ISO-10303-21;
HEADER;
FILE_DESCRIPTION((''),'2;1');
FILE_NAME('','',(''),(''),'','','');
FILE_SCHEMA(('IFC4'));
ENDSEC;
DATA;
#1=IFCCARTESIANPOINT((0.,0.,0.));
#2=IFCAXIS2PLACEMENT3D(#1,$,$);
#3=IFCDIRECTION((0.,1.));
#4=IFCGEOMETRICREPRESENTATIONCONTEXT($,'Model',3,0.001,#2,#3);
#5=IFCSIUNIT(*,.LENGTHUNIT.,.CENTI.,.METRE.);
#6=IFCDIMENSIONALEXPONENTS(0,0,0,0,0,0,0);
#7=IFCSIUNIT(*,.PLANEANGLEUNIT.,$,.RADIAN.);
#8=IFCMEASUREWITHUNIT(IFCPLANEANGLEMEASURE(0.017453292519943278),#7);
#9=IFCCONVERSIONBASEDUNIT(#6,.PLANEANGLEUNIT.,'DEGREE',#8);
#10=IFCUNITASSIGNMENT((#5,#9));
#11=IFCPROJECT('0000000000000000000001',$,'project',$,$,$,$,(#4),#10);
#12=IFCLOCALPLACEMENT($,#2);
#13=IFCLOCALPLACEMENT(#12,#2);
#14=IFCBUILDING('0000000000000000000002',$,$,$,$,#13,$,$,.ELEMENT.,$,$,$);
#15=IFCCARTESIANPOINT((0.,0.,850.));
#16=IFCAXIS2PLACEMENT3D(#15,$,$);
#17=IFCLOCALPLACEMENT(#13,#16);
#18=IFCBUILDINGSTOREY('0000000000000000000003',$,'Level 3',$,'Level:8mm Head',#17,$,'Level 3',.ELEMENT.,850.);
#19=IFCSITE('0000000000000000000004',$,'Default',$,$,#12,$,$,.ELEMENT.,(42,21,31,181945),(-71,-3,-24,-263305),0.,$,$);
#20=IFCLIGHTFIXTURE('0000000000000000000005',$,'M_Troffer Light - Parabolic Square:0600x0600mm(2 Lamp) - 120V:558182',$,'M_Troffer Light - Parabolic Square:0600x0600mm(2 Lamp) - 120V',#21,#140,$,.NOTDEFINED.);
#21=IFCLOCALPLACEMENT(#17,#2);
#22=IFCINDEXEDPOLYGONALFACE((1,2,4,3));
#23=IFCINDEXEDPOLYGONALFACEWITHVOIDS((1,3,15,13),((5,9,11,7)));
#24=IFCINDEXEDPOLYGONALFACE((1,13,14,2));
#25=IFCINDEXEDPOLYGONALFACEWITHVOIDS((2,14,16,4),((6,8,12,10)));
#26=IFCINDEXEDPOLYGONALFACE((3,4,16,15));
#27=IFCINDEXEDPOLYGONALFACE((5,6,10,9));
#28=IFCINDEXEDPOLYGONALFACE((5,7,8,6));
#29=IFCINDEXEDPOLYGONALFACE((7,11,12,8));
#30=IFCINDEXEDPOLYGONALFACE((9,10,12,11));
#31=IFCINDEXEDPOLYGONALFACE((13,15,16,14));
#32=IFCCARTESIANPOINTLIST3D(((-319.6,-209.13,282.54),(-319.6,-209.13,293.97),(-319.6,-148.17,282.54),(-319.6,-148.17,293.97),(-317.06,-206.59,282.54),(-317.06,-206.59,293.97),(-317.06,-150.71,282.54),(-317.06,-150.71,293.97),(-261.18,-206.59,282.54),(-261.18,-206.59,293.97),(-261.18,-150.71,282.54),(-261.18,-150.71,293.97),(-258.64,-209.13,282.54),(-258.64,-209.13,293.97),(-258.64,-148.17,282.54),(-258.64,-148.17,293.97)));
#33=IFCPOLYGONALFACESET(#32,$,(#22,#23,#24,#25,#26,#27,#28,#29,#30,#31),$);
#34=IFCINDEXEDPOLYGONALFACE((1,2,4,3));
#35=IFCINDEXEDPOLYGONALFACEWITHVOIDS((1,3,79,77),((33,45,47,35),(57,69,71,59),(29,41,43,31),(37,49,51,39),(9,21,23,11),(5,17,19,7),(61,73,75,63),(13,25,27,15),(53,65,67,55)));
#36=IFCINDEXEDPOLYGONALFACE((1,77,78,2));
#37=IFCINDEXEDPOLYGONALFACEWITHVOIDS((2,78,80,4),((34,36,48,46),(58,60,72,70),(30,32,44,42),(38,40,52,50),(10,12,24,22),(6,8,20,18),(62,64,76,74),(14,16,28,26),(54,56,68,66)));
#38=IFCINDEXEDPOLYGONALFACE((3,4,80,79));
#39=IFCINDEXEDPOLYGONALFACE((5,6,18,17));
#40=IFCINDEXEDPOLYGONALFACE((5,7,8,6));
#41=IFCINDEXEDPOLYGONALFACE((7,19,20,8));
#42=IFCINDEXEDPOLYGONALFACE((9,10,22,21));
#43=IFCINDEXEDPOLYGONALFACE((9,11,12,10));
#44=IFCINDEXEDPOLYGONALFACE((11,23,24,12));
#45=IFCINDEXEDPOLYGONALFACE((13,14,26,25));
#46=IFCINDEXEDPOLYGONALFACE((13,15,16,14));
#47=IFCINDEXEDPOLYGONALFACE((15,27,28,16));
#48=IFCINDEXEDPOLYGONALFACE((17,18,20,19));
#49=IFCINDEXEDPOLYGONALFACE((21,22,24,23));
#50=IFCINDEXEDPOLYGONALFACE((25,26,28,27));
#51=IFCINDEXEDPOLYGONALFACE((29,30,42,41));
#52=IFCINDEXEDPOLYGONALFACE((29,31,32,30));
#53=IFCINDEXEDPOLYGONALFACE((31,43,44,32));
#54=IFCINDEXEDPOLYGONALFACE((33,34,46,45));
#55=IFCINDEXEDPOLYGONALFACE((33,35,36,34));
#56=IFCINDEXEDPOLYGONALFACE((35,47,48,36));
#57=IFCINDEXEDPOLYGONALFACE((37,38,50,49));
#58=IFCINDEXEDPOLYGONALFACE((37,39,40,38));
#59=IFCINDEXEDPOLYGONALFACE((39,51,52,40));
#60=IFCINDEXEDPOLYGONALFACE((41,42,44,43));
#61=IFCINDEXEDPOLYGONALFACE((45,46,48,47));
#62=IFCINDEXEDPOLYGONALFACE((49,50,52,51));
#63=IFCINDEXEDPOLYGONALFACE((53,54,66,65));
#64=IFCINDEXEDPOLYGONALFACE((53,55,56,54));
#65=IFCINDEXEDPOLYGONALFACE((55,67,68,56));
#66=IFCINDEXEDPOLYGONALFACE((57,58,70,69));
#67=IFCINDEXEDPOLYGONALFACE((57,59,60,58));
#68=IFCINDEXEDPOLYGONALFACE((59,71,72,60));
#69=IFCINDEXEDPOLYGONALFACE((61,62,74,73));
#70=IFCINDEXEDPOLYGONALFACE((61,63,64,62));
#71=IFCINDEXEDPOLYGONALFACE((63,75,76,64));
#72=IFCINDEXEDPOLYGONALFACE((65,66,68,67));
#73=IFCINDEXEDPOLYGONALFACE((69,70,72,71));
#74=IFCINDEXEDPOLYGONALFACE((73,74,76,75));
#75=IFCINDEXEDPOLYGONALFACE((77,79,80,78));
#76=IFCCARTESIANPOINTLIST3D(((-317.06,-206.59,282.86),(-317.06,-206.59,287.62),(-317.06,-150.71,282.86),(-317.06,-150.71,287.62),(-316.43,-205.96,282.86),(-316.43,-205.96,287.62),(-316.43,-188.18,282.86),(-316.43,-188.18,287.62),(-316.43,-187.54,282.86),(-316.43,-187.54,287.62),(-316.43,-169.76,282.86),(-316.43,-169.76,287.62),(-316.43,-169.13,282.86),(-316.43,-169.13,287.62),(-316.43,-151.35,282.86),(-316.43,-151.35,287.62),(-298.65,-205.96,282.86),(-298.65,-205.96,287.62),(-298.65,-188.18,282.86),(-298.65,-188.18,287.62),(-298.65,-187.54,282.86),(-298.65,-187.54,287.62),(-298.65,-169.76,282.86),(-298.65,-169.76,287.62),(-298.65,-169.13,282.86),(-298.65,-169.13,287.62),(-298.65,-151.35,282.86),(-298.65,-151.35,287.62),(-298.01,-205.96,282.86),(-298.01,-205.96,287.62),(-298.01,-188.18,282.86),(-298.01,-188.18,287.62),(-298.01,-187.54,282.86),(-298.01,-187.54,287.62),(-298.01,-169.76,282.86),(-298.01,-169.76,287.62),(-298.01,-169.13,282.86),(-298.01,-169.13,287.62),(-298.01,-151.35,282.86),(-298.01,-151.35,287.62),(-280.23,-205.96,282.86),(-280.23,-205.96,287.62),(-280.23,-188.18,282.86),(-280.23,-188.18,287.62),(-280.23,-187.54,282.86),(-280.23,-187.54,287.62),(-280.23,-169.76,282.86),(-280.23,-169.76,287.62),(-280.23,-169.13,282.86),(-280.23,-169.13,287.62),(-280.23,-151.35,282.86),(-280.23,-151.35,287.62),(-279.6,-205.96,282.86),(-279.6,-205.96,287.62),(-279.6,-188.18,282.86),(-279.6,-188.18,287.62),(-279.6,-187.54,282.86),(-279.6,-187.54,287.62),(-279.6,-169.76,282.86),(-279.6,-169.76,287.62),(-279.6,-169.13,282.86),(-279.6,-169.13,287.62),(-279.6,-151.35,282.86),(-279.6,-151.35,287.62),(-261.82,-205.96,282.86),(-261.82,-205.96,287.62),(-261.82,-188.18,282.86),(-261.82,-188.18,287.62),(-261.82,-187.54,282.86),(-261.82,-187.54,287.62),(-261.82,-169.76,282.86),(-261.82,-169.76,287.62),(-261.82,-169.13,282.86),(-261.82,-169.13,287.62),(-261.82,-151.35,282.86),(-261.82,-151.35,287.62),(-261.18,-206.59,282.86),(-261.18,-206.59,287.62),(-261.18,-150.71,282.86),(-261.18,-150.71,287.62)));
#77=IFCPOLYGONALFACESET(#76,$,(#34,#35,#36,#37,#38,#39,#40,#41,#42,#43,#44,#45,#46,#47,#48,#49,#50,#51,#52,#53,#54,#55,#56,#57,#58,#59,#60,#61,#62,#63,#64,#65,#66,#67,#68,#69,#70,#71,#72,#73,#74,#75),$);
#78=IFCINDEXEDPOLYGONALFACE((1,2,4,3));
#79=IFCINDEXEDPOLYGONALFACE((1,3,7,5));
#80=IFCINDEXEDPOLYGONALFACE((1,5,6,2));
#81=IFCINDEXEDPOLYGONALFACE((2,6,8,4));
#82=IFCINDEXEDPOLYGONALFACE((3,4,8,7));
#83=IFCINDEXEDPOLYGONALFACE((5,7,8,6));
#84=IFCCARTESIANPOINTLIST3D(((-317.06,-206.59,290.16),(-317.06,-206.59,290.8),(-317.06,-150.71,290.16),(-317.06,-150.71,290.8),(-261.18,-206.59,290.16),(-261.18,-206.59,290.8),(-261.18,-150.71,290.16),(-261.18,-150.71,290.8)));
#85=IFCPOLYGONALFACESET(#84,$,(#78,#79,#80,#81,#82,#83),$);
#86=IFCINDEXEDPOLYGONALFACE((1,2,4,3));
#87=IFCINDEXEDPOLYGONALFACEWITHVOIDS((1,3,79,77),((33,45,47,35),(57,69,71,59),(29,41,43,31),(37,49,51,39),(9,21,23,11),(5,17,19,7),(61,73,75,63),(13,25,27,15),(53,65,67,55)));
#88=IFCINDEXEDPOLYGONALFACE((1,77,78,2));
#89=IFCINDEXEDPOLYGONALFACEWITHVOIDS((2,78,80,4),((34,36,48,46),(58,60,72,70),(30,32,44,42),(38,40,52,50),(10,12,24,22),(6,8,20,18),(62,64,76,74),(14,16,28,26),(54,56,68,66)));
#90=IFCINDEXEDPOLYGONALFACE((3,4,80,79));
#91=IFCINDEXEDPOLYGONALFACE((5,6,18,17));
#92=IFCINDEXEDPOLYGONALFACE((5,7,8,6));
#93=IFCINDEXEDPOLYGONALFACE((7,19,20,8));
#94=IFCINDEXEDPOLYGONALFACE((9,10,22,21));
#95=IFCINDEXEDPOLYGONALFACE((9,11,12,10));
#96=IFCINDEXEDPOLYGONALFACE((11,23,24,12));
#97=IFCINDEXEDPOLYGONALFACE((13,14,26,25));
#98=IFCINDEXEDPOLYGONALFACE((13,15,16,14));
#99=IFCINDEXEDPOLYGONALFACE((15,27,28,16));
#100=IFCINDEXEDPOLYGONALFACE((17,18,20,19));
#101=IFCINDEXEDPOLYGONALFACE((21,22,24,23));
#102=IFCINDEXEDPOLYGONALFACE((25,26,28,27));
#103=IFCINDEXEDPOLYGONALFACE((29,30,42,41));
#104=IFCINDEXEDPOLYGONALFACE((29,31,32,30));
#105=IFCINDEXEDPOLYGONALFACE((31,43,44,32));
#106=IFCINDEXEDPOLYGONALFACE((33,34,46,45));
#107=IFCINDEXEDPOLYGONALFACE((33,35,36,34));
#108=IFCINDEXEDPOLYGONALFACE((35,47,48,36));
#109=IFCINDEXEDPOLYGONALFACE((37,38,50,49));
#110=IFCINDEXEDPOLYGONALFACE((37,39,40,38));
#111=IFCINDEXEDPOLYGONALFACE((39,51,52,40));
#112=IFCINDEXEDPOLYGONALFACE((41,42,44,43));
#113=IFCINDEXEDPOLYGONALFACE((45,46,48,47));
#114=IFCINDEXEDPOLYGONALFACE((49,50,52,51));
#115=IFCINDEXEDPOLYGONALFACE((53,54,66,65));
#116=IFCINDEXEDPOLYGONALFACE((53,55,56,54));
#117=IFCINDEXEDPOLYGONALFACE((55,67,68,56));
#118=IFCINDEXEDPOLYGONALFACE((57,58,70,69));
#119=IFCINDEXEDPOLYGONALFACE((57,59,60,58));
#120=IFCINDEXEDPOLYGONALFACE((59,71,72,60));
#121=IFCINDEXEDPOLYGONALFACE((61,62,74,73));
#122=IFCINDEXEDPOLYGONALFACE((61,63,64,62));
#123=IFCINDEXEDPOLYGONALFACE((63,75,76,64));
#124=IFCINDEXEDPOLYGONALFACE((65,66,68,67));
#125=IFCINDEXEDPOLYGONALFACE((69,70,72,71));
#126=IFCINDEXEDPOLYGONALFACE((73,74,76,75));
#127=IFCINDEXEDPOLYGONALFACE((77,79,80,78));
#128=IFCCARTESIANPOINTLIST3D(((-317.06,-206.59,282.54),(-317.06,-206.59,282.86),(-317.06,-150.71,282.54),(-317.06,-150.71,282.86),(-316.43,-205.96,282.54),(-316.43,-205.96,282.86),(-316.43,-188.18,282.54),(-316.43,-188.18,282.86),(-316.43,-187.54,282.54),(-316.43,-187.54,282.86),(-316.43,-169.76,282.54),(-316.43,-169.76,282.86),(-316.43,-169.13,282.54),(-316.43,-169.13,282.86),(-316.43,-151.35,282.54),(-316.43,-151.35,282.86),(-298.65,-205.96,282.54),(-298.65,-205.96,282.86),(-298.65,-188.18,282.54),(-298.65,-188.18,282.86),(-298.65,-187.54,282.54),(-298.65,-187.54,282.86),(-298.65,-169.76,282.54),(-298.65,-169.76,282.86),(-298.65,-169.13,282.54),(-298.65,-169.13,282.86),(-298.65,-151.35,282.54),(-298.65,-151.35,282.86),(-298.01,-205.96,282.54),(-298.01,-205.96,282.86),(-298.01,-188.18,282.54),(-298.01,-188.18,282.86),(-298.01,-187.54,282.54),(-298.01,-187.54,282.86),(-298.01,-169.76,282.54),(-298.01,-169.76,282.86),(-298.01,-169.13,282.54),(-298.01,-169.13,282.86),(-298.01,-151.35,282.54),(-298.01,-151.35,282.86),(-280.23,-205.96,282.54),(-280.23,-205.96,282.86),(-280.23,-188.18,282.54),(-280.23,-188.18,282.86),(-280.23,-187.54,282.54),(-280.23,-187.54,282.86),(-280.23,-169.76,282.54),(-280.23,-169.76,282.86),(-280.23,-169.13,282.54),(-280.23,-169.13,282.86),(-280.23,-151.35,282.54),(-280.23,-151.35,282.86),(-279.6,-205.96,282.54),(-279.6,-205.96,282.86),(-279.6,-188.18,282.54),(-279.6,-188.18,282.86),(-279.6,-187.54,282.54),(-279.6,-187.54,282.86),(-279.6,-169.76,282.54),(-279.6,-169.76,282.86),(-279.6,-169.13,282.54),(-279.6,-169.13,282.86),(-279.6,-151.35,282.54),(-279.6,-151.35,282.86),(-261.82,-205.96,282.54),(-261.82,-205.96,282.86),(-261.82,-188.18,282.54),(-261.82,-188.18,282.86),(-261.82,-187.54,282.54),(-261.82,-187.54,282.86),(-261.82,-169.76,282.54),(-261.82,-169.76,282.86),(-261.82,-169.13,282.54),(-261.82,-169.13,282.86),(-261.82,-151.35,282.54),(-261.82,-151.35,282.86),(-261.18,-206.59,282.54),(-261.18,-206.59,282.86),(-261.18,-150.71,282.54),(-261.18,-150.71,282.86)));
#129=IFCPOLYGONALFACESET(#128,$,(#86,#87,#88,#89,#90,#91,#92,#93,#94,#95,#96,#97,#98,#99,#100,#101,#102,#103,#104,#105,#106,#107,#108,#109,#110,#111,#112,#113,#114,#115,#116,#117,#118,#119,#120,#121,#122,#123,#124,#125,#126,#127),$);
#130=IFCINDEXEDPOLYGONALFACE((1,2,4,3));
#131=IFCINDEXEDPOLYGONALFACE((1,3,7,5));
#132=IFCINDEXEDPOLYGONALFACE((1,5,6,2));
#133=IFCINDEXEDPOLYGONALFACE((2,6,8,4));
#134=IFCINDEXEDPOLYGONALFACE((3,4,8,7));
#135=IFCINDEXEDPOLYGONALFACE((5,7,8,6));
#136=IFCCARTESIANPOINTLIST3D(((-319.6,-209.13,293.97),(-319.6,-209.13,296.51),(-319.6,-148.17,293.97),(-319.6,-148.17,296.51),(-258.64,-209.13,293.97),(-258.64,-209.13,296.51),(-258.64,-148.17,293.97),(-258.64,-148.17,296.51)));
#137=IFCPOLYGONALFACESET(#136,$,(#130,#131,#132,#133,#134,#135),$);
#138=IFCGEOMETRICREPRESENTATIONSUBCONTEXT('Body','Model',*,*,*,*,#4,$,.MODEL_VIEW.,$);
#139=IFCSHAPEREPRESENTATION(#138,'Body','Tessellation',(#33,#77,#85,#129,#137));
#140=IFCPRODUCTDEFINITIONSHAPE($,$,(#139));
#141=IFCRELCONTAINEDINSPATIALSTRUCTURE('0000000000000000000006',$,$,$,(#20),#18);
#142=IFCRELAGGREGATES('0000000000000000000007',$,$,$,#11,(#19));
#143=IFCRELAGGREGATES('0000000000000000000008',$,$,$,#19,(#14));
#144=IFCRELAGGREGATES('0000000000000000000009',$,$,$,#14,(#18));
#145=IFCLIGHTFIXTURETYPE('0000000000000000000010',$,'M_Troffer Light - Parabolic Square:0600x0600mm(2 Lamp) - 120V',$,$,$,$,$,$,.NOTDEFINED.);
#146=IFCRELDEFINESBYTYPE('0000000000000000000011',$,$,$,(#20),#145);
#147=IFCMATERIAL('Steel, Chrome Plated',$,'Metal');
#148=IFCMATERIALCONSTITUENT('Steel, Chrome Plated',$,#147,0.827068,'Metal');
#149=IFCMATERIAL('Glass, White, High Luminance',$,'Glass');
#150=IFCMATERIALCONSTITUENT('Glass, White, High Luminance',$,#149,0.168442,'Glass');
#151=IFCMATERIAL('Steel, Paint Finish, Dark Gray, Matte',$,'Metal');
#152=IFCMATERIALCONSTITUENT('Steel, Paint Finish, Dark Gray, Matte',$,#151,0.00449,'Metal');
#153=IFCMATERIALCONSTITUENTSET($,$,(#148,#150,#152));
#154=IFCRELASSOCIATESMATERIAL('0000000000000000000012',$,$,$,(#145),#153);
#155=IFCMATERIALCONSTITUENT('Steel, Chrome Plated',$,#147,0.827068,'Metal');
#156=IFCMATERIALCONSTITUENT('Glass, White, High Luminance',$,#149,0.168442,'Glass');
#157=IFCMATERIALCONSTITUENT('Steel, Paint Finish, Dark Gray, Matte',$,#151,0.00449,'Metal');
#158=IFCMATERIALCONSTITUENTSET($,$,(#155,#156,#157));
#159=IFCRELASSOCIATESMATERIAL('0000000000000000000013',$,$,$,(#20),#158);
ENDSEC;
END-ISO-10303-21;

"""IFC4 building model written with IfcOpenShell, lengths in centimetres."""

from ifc_helpers import new_model, entity, si_unit, converted_unit, direction, frame, origin, place, context, subcontext, project, spatial, indexed_curve, outline, extrude, source, transform, mapped, material, constituent, constituent_set, type_object, type_shapes, element, save


model = new_model("IFC4")

# Units and contexts
model_context = context("Model", 3, precision=0.001, world=origin(), true_north=direction((0.0, 1.0)))
body_context = subcontext(model_context, "Body", "Model", "MODEL_VIEW")
ifc_project = project(units=[si_unit("LENGTHUNIT", "METRE", prefix="CENTI"), converted_unit("PLANEANGLEUNIT", "DEGREE", entity("IfcPlaneAngleMeasure", 0.017453292519943278), si_unit("PLANEANGLEUNIT", "RADIAN"), dimensions=[0, 0, 0, 0, 0, 0, 0])], contexts=[model_context])

# Site, building, storey
site_placement = place(None, origin())
site = spatial("IfcSite", under=ifc_project, at=site_placement, Name="Default", CompositionType="ELEMENT", RefLatitude=(42, 21, 31, 181945), RefLongitude=(-71, -3, -24, -263305), RefElevation=0.0)
building_placement = place(site_placement, origin())
building = spatial("IfcBuilding", under=site, at=building_placement, CompositionType="ELEMENT")
storey_placement = place(building_placement, frame((0.0, 0.0, 850.0)))
storey = spatial("IfcBuildingStorey", under=building, at=storey_placement, Name="Level 3", ObjectType="Level:8mm Head", LongName="Level 3", CompositionType="ELEMENT", Elevation=850.0)

# Light fixture
ifc_material_1 = material(Name="Steel, Chrome Plated", Category="Metal")
ifc_material_2 = material(Name="Glass, White, High Luminance", Category="Glass")
ifc_material_3 = material(Name="Steel, Paint Finish, Dark Gray, Matte", Category="Metal")
ifc_constituent_1 = constituent(ifc_material_1, Name="Steel, Chrome Plated", Category="Metal", fraction=0.827068)
ifc_constituent_2 = constituent(ifc_material_2, Name="Glass, White, High Luminance", Category="Glass", fraction=0.168442)
ifc_constituent_3 = constituent(ifc_material_3, Name="Steel, Paint Finish, Dark Gray, Matte", Category="Metal", fraction=0.00449)
ifc_constituent_set_1 = constituent_set(constituents=[ifc_constituent_1, ifc_constituent_2, ifc_constituent_3])
ifc_constituent_4 = constituent(ifc_material_1, Name="Steel, Chrome Plated", Category="Metal", fraction=0.827068)
ifc_constituent_5 = constituent(ifc_material_2, Name="Glass, White, High Luminance", Category="Glass", fraction=0.168442)
ifc_constituent_6 = constituent(ifc_material_3, Name="Steel, Paint Finish, Dark Gray, Matte", Category="Metal", fraction=0.00449)
ifc_constituent_set_2 = constituent_set(constituents=[ifc_constituent_4, ifc_constituent_5, ifc_constituent_6])
light_fixture_type_1 = type_object("IfcLightFixtureType", Name="M_Troffer Light - Parabolic Square:0600x0600mm(2 Lamp) - 120V", PredefinedType="NOTDEFINED", material=ifc_constituent_set_2)
shared_shape_1 = source(origin(), body_context, "Body", "SweptSolid", [
    extrude(outline(indexed_curve([(-30.48, -30.48), (30.48, -30.48), (30.48, 30.48), (-30.48, 30.48), (-30.48, -30.48)], self_intersect=False), holes=[indexed_curve([(-27.94, -27.94), (-27.94, 27.94), (27.94, 27.94), (27.94, -27.94), (-27.94, -27.94)], self_intersect=False)]), frame((-1.87, -5.95, 243.84), z_axis=(0.0, 0.0, 1.0), x_axis=(-1.0, 0.0, 0.0)), (0.0, 0.0, 1.0), 11.43),
    extrude(outline(indexed_curve([(-27.94, -27.94), (27.94, -27.94), (27.94, 27.94), (-27.94, 27.94), (-27.94, -27.94)], self_intersect=False), holes=[indexed_curve([(9.52, -9.52), (27.31, -9.52), (27.31, -27.3), (9.52, -27.3), (9.52, -9.52)], self_intersect=False), indexed_curve([(9.52, 8.89), (27.3, 8.89), (27.3, -8.89), (9.52, -8.89), (9.52, 8.89)], self_intersect=False), indexed_curve([(9.52, 9.53), (9.52, 27.31), (27.3, 27.31), (27.3, 9.53), (9.52, 9.53)], self_intersect=False), indexed_curve([(-8.89, -9.52), (8.89, -9.52), (8.89, -27.3), (-8.89, -27.3), (-8.89, -9.52)], self_intersect=False), indexed_curve([(-8.89, 8.89), (8.89, 8.89), (8.89, -8.89), (-8.89, -8.89), (-8.89, 8.89)], self_intersect=False), indexed_curve([(-8.89, 9.53), (-8.89, 27.31), (8.89, 27.31), (8.89, 9.53), (-8.89, 9.53)], self_intersect=False), indexed_curve([(-27.31, -9.52), (-9.53, -9.52), (-9.53, -27.31), (-27.31, -27.31), (-27.31, -9.52)], self_intersect=False), indexed_curve([(-27.31, 8.89), (-9.52, 8.89), (-9.52, -8.89), (-27.31, -8.89), (-27.31, 8.89)], self_intersect=False), indexed_curve([(-27.31, 9.53), (-27.31, 27.31), (-9.52, 27.31), (-9.52, 9.53), (-27.31, 9.53)], self_intersect=False)]), frame((-1.87, -5.95, 244.16), z_axis=(0.0, 0.0, 1.0), x_axis=(-1.0, 0.0, 0.0)), (0.0, 0.0, 1.0), 4.76),
    extrude(outline(indexed_curve([(-27.94, -27.94), (27.94, -27.94), (27.94, 27.94), (-27.94, 27.94), (-27.94, -27.94)], self_intersect=False)), frame((-1.87, -5.95, 251.46), z_axis=(0.0, 0.0, 1.0), x_axis=(-1.0, 0.0, 0.0)), (0.0, 0.0, 1.0), 0.64),
    extrude(outline(indexed_curve([(-27.94, -27.94), (27.94, -27.94), (27.94, 27.94), (-27.94, 27.94), (-27.94, -27.94)], self_intersect=False), holes=[indexed_curve([(9.52, -9.52), (27.31, -9.52), (27.31, -27.3), (9.52, -27.3), (9.52, -9.52)], self_intersect=False), indexed_curve([(9.52, 8.89), (27.3, 8.89), (27.3, -8.89), (9.52, -8.89), (9.52, 8.89)], self_intersect=False), indexed_curve([(9.52, 9.53), (9.52, 27.31), (27.3, 27.31), (27.3, 9.53), (9.52, 9.53)], self_intersect=False), indexed_curve([(-8.89, -9.52), (8.89, -9.52), (8.89, -27.3), (-8.89, -27.3), (-8.89, -9.52)], self_intersect=False), indexed_curve([(-8.89, 8.89), (8.89, 8.89), (8.89, -8.89), (-8.89, -8.89), (-8.89, 8.89)], self_intersect=False), indexed_curve([(-8.89, 9.53), (-8.89, 27.31), (8.89, 27.31), (8.89, 9.53), (-8.89, 9.53)], self_intersect=False), indexed_curve([(-27.31, -9.52), (-9.53, -9.52), (-9.53, -27.31), (-27.31, -27.31), (-27.31, -9.52)], self_intersect=False), indexed_curve([(-27.31, 8.89), (-9.52, 8.89), (-9.52, -8.89), (-27.31, -8.89), (-27.31, 8.89)], self_intersect=False), indexed_curve([(-27.31, 9.53), (-27.31, 27.31), (-9.52, 27.31), (-9.52, 9.53), (-27.31, 9.53)], self_intersect=False)]), frame((-1.87, -5.95, 243.84), z_axis=(0.0, 0.0, 1.0), x_axis=(-1.0, 0.0, 0.0)), (0.0, 0.0, 1.0), 0.32),
    extrude(outline(indexed_curve([(-30.48, -30.48), (30.48, -30.48), (30.48, 30.48), (-30.48, 30.48), (-30.48, -30.48)], self_intersect=False)), frame((-1.87, -5.95, 255.27), z_axis=(0.0, 0.0, 1.0), x_axis=(-1.0, 0.0, 0.0)), (0.0, 0.0, 1.0), 2.54),
])
type_shapes(light_fixture_type_1, [shared_shape_1])
light_fixture_1_placement = place(storey_placement, frame((-287.25, -172.71, 38.7)))
element("IfcLightFixture", 1, at=light_fixture_1_placement, inside=storey, type_object=light_fixture_type_1, material=ifc_constituent_set_1, Name="M_Troffer Light - Parabolic Square:0600x0600mm(2 Lamp) - 120V:558182", ObjectType="M_Troffer Light - Parabolic Square:0600x0600mm(2 Lamp) - 120V", PredefinedType="NOTDEFINED", context=body_context, shape_type="MappedRepresentation", body=[
    mapped(shared_shape_1, transform((0.0, 0.0, 0.0), scale=1.0)),
])

save(model, "model.ifc")
